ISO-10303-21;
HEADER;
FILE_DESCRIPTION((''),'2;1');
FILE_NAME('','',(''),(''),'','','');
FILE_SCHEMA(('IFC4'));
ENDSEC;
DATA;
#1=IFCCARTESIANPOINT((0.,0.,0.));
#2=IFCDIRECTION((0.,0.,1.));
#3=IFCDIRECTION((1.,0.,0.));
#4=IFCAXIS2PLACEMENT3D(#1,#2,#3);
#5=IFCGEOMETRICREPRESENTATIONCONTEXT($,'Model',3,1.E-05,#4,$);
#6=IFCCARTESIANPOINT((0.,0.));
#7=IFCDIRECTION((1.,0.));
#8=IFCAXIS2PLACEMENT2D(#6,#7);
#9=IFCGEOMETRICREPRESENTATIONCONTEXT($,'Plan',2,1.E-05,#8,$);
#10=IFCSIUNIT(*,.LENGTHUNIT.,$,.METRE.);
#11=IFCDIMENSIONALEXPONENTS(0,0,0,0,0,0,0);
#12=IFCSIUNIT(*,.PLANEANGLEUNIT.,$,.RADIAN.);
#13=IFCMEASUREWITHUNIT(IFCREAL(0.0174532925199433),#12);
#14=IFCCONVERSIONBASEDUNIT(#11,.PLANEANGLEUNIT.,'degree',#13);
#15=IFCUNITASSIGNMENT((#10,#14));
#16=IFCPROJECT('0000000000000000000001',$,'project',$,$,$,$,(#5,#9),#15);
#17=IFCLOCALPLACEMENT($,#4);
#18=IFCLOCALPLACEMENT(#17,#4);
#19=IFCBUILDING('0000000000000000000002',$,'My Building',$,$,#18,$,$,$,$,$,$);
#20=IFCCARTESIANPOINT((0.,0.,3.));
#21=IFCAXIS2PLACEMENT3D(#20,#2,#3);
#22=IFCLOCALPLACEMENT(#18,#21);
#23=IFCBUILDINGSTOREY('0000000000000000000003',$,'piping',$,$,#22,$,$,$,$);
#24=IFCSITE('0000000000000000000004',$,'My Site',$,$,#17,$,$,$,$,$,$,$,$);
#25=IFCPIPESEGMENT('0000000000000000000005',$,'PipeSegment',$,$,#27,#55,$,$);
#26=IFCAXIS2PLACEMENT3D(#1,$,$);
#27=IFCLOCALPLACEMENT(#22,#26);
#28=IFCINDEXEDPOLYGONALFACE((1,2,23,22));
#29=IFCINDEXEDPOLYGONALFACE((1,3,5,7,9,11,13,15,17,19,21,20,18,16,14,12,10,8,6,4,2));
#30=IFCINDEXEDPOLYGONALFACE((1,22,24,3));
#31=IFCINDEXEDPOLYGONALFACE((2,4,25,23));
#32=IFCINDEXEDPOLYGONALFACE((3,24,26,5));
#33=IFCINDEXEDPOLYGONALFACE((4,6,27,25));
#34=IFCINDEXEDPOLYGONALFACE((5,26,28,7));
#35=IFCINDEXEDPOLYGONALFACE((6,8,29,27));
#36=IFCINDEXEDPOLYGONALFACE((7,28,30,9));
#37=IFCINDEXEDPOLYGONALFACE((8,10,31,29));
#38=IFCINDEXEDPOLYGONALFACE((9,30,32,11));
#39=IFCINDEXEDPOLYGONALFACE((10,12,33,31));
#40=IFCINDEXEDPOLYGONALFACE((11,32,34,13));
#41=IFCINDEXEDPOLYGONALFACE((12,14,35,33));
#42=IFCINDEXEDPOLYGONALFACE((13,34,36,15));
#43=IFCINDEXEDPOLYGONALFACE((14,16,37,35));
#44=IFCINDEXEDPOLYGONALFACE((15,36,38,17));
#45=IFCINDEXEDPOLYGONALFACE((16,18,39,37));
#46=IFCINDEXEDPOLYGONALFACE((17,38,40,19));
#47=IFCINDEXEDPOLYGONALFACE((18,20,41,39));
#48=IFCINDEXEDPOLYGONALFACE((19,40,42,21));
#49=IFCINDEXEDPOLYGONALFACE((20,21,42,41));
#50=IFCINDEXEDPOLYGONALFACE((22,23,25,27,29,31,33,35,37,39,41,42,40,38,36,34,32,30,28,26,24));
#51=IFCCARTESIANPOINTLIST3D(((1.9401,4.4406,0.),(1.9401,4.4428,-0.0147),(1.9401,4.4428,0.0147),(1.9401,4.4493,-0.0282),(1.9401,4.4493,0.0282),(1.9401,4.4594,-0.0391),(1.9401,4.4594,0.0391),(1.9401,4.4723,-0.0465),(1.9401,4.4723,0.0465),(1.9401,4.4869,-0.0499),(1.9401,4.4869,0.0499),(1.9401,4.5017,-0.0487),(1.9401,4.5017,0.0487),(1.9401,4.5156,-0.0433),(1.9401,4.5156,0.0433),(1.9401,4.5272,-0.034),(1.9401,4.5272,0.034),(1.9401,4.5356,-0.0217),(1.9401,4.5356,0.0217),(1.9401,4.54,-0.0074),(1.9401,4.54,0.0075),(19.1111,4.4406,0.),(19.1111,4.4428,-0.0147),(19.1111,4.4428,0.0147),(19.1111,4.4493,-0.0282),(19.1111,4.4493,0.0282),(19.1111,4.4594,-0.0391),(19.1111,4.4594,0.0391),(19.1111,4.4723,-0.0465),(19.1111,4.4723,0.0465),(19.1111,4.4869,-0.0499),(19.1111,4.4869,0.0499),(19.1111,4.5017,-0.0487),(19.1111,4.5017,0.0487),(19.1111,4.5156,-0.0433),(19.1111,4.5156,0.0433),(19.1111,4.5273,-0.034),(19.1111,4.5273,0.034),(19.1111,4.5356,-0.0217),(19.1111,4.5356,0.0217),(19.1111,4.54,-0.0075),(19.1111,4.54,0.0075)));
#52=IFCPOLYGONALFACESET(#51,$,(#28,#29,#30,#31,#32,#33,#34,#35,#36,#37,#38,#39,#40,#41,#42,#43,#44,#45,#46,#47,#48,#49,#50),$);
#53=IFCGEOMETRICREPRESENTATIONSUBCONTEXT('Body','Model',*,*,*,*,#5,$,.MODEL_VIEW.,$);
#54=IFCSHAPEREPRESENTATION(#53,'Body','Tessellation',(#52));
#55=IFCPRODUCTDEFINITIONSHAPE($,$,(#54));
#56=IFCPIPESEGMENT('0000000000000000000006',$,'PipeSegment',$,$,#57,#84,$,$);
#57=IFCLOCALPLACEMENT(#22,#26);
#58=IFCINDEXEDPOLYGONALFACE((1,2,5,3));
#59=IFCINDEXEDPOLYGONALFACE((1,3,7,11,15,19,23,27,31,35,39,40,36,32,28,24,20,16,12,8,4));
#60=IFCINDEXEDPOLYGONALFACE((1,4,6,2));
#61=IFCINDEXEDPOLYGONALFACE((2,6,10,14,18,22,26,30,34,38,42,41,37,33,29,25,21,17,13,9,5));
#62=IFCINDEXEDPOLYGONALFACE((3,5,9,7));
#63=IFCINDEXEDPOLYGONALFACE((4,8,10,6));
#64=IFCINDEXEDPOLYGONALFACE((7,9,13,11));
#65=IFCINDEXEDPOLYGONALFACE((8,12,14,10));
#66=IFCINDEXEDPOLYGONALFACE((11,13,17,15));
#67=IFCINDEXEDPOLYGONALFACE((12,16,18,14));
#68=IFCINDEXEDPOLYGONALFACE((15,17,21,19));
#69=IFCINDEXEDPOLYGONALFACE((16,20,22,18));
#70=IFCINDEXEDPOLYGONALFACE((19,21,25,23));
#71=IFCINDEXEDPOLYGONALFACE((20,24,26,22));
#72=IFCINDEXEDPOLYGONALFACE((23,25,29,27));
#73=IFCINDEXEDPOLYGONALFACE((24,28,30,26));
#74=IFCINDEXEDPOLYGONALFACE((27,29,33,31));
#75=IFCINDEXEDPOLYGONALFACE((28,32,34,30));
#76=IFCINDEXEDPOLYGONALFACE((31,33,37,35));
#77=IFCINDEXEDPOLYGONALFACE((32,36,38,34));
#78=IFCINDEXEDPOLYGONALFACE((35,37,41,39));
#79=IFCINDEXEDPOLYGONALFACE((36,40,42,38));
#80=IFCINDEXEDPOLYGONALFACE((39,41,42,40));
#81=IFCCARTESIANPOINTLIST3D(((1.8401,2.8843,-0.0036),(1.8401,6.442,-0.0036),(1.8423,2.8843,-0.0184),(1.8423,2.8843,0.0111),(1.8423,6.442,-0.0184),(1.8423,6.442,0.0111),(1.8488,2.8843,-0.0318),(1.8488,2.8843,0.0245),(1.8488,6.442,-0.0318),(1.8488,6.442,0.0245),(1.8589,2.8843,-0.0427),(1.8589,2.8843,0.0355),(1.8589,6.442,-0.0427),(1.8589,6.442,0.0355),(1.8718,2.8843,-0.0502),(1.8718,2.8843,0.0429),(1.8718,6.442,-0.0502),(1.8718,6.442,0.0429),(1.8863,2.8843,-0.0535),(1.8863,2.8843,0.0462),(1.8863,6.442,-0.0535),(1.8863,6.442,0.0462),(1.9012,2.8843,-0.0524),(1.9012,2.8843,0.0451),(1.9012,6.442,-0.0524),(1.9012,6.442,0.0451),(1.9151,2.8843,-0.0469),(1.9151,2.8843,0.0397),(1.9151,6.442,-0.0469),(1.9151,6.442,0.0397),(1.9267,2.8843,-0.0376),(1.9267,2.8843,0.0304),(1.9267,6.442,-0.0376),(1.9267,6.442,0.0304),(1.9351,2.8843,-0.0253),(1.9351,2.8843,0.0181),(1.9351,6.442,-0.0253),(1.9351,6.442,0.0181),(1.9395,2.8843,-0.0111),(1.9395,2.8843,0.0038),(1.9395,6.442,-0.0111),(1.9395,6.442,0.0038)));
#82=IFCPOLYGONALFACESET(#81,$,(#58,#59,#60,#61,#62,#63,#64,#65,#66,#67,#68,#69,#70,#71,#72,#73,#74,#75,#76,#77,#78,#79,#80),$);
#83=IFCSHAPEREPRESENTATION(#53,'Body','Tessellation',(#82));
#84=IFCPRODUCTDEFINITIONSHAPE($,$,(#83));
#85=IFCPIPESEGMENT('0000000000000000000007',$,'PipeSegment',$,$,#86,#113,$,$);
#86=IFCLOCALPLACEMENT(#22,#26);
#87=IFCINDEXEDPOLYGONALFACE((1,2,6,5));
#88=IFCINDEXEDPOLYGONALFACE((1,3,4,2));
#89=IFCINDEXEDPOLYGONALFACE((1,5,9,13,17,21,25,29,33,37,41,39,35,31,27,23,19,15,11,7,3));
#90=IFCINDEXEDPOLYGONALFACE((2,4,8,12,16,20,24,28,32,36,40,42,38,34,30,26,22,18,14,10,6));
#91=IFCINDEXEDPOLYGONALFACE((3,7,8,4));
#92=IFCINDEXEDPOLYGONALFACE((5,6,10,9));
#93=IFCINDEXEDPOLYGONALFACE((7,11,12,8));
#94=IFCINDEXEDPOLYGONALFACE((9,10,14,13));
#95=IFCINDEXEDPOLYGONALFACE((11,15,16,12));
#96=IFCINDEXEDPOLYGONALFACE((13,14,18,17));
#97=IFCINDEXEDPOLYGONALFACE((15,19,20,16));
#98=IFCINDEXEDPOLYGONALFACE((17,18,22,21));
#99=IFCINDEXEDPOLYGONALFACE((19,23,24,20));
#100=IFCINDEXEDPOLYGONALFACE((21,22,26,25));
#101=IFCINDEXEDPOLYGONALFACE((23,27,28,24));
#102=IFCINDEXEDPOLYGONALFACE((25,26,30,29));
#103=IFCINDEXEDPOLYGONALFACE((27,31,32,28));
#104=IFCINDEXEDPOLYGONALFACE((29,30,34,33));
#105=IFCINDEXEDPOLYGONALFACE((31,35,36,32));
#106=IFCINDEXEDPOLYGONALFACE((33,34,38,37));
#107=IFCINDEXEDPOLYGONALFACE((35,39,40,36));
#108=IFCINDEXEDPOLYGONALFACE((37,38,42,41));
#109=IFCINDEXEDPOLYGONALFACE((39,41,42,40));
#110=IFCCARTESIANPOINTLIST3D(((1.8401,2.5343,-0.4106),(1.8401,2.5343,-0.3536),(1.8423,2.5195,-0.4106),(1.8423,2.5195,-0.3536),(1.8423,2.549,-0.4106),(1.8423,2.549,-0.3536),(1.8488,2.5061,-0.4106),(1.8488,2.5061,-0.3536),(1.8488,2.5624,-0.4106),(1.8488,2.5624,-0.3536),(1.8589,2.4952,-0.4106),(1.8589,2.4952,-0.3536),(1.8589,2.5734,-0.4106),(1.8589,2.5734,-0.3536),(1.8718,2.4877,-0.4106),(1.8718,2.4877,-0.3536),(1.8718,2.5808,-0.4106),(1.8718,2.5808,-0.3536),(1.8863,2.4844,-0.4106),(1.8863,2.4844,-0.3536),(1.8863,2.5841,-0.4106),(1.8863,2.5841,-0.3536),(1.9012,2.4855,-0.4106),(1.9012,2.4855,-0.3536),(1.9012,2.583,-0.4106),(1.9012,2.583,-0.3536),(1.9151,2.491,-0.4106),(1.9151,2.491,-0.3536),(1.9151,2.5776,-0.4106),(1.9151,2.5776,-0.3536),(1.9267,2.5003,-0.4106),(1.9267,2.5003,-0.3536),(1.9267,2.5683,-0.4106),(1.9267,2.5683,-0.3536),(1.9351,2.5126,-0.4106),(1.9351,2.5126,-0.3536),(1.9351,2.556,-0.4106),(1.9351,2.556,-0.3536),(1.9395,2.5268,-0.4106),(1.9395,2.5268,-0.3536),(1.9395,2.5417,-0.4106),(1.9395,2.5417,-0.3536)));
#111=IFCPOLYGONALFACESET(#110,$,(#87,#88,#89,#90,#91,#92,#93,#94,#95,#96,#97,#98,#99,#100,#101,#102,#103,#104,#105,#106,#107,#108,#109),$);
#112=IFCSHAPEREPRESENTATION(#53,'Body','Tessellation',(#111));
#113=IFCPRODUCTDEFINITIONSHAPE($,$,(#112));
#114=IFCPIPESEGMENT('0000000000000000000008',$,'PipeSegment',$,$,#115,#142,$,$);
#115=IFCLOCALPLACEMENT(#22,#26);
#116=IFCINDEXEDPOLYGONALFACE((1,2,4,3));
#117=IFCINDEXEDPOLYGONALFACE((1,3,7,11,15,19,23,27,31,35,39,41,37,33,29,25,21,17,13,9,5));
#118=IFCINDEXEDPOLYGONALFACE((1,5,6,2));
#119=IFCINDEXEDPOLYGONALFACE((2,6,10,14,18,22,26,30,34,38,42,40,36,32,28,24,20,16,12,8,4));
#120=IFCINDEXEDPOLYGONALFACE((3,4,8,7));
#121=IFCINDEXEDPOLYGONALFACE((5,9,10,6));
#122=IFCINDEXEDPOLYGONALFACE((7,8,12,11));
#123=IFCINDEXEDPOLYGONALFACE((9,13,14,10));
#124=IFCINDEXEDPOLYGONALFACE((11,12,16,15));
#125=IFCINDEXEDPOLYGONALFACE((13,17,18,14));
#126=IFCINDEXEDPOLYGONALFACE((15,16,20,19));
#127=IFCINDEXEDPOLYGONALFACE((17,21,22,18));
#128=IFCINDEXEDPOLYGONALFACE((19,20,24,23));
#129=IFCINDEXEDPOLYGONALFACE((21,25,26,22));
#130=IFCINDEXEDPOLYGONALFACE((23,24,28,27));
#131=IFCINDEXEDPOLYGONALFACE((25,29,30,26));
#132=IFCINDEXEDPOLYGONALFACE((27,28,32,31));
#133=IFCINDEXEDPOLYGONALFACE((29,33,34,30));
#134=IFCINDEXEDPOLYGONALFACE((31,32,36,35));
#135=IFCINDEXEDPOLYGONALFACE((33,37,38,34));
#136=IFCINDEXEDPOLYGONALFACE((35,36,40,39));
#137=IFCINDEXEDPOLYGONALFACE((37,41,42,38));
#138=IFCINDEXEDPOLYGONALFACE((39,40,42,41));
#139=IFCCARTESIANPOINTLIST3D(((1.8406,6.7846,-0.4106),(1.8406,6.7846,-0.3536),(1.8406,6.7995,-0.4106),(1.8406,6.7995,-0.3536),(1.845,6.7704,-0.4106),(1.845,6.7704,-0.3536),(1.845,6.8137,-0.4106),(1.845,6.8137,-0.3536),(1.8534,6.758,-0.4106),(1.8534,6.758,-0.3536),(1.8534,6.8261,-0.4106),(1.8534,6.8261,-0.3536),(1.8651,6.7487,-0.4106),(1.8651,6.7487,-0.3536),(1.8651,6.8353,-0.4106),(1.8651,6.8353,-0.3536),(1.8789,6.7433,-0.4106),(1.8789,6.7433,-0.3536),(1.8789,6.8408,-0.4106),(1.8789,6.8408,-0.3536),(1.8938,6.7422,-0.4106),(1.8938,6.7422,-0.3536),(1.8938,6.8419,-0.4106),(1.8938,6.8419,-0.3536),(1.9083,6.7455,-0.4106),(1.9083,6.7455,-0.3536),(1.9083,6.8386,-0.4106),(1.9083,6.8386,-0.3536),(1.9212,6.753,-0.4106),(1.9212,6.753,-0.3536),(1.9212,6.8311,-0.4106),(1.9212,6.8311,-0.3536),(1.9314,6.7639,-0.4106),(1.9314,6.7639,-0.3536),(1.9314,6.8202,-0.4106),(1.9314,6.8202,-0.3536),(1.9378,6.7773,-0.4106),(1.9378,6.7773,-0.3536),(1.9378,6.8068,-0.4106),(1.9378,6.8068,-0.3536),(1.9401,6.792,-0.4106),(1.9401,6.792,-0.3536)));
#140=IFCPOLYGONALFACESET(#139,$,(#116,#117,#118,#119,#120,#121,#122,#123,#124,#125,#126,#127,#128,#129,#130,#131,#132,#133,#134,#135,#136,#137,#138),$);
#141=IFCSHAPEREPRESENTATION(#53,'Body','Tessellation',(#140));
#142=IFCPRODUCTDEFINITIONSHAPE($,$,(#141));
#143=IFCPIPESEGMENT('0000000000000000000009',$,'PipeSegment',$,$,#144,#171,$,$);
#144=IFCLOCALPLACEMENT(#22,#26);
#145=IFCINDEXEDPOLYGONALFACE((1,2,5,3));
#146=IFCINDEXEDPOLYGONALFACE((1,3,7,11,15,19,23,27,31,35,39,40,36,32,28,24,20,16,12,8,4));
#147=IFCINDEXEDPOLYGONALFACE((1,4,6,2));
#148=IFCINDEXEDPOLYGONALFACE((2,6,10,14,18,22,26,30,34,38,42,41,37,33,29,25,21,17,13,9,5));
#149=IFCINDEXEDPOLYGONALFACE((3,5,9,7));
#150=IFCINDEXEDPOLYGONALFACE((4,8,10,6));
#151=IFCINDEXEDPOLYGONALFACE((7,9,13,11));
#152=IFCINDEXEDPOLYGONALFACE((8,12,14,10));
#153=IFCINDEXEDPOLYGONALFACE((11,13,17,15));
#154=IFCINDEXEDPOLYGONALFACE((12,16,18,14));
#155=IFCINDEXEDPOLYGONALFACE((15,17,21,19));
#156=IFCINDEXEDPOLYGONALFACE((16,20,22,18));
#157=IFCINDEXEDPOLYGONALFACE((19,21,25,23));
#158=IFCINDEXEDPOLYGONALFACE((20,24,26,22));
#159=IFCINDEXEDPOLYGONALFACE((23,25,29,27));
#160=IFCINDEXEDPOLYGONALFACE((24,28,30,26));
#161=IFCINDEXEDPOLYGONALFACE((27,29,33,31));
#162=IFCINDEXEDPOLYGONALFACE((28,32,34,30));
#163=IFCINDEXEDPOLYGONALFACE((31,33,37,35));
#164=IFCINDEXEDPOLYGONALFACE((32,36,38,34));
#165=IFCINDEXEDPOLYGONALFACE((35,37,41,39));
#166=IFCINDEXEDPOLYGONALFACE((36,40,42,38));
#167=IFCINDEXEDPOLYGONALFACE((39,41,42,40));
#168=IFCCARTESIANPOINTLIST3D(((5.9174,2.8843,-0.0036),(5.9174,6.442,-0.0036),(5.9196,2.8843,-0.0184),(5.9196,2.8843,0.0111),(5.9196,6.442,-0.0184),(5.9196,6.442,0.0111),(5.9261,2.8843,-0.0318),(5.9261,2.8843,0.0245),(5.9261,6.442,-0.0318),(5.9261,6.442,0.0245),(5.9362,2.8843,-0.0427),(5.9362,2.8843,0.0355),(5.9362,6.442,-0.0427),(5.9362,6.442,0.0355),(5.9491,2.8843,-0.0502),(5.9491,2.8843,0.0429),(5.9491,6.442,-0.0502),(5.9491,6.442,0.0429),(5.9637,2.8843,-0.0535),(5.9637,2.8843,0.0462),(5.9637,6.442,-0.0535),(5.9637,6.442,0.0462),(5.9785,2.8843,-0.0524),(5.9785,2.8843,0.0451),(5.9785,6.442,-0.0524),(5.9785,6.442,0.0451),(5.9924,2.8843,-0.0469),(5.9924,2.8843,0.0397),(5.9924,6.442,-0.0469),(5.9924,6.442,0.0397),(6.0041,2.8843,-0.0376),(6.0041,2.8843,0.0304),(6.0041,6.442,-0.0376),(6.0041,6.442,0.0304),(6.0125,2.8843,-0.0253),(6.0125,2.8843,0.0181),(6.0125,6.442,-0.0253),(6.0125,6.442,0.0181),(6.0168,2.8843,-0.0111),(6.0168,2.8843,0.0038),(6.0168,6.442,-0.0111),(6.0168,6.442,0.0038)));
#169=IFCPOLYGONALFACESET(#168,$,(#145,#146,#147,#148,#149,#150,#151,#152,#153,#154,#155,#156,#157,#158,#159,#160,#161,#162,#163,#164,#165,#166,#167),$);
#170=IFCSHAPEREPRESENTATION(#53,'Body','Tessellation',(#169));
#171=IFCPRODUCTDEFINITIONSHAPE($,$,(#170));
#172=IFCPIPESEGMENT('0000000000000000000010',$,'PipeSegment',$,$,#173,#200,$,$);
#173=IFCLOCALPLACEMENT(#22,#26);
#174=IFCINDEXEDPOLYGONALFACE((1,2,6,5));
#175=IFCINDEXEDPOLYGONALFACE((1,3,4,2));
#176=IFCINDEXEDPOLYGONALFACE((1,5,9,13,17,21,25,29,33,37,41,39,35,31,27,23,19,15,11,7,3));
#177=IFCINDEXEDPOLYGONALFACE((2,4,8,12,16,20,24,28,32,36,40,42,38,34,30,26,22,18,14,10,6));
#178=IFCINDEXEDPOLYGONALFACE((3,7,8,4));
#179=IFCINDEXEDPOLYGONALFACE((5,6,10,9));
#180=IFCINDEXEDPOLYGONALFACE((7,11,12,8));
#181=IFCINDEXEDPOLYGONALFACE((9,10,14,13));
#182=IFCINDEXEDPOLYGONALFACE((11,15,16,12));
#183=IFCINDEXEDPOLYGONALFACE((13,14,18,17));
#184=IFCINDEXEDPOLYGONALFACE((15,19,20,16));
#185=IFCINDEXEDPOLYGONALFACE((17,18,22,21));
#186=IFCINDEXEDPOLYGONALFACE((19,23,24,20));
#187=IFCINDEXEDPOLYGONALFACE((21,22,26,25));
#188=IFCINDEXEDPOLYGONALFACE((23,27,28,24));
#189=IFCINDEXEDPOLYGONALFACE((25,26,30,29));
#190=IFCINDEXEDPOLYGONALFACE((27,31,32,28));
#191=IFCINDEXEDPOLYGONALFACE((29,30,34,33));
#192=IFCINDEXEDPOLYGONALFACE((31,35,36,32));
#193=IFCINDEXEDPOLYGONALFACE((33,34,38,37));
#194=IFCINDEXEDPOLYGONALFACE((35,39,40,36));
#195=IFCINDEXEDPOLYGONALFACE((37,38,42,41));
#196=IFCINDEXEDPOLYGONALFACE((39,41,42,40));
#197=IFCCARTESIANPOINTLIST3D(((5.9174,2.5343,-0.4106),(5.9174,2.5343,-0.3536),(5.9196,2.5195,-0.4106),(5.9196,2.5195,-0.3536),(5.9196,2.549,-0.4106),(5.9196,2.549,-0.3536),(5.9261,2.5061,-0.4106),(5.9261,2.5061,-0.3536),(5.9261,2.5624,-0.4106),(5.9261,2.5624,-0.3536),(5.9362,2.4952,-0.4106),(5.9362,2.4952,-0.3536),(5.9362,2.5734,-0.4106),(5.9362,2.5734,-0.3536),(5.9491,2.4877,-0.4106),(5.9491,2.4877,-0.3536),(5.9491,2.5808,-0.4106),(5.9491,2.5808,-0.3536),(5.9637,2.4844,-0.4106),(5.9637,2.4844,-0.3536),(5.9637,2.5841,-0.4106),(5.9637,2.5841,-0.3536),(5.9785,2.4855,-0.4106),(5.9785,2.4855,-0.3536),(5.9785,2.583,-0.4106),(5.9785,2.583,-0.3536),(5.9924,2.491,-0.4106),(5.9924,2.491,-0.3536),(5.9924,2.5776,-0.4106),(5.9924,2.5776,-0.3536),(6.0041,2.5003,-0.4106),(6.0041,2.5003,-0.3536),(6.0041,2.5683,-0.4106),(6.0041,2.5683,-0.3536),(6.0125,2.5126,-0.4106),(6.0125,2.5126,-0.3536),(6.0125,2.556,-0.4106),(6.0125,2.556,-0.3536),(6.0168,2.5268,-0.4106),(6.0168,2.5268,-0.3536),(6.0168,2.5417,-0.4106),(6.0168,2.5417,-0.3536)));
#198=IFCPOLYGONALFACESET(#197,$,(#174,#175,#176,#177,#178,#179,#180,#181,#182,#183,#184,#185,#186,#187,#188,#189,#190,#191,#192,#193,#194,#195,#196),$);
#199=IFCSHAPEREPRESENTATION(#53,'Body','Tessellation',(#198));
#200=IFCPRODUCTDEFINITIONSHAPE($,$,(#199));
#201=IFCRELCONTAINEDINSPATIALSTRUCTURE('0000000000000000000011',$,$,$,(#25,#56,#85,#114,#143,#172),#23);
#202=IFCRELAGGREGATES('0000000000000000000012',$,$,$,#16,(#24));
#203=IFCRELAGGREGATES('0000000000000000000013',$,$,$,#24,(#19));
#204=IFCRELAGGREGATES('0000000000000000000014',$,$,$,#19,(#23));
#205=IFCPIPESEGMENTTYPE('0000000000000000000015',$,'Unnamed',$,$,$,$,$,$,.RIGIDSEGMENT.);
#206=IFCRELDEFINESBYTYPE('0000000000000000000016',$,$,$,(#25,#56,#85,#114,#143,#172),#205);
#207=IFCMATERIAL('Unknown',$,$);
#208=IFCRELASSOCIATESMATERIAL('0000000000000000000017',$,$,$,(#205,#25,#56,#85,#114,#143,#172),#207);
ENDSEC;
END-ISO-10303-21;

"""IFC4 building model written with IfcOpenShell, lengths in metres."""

from ifc_helpers import new_model, entity, si_unit, converted_unit, frame, origin_with_axes, origin_2d_with_axis, place, context, subcontext, project, spatial, circle, extrude, material, material_profile, profile_set, profile_usage, type_object, element, save


model = new_model("IFC4")

# Units and contexts
model_context = context("Model", 3, precision=1e-05, world=origin_with_axes())
plan_context = context("Plan", 2, precision=1e-05, world=origin_2d_with_axis())
body_context = subcontext(model_context, "Body", "Model", "MODEL_VIEW")
ifc_project = project(units=[si_unit("LENGTHUNIT", "METRE"), converted_unit("PLANEANGLEUNIT", "degree", entity("IfcReal", 0.0174532925199433), si_unit("PLANEANGLEUNIT", "RADIAN"), dimensions=[0, 0, 0, 0, 0, 0, 0])], contexts=[model_context, plan_context])

# Site, building, storey
site_placement = place(None, origin_with_axes())
site = spatial("IfcSite", under=ifc_project, at=site_placement, Name="My Site")
building_placement = place(site_placement, origin_with_axes())
building = spatial("IfcBuilding", under=site, at=building_placement, Name="My Building")
storey_placement = place(building_placement, frame((0.0, 0.0, 3.0), z_axis=(0.0, 0.0, 1.0), x_axis=(1.0, 0.0, 0.0)))
storey = spatial("IfcBuildingStorey", under=building, at=storey_placement, Name="piping")

# Pipe segments
ifc_material = material(Name="Unknown")
ifc_material_profile = material_profile(ifc_material, circle(Radius=0.05))
ifc_profile_set = profile_set([ifc_material_profile])
ifc_profile_usage_1 = profile_usage(ifc_profile_set, cardinal=5)
pipe_segment_type = type_object("IfcPipeSegmentType", Name="Unnamed", PredefinedType="RIGIDSEGMENT", material=ifc_profile_set)
pipe_segment_1_placement = place(storey_placement, frame((19.1111, 4.4906, 0.0), z_axis=(-1.0, 0.0, 0.0), x_axis=(0.0, -1.0, 0.0)))
element("IfcPipeSegment", 1, at=pipe_segment_1_placement, inside=storey, type_object=pipe_segment_type, material=ifc_profile_usage_1, Name="PipeSegment", context=body_context, shape_type="SweptSolid", body=[
    extrude(circle(Radius=0.05), origin_with_axes(), (0.0, 0.0, 1.0), 17.1711),
])
ifc_profile_usage_2 = profile_usage(ifc_profile_set, cardinal=5)
pipe_segment_2_placement = place(storey_placement, frame((1.8901, 2.8843, -0.0036), z_axis=(0.0, 1.0, 0.0), x_axis=(-1.0, 0.0, 0.0)))
element("IfcPipeSegment", 2, at=pipe_segment_2_placement, inside=storey, type_object=pipe_segment_type, material=ifc_profile_usage_2, Name="PipeSegment", context=body_context, shape_type="SweptSolid", body=[
    extrude(circle(Radius=0.05), origin_with_axes(), (0.0, 0.0, 1.0), 3.5578),
])
ifc_profile_usage_3 = profile_usage(ifc_profile_set, cardinal=5)
pipe_segment_3_placement = place(storey_placement, frame((1.8901, 2.5343, -0.3536), z_axis=(0.0, 0.0, -1.0), x_axis=(-1.0, 0.0, 0.0)))
element("IfcPipeSegment", 3, at=pipe_segment_3_placement, inside=storey, type_object=pipe_segment_type, material=ifc_profile_usage_3, Name="PipeSegment", context=body_context, shape_type="SweptSolid", body=[
    extrude(circle(Radius=0.05), origin_with_axes(), (0.0, 0.0, 1.0), 0.057),
])
ifc_profile_usage_4 = profile_usage(ifc_profile_set, cardinal=5)
pipe_segment_4_placement = place(storey_placement, frame((1.8901, 6.792, -0.3536), z_axis=(0.0, 0.0, -1.0), x_axis=(1.0, 0.0, 0.0)))
element("IfcPipeSegment", 4, at=pipe_segment_4_placement, inside=storey, type_object=pipe_segment_type, material=ifc_profile_usage_4, Name="PipeSegment", context=body_context, shape_type="SweptSolid", body=[
    extrude(circle(Radius=0.05), origin_with_axes(), (0.0, 0.0, 1.0), 0.057),
])
ifc_profile_usage_5 = profile_usage(ifc_profile_set, cardinal=5)
pipe_segment_5_placement = place(storey_placement, frame((5.9674, 2.8843, -0.0036), z_axis=(0.0, 1.0, 0.0), x_axis=(-1.0, 0.0, 0.0)))
element("IfcPipeSegment", 5, at=pipe_segment_5_placement, inside=storey, type_object=pipe_segment_type, material=ifc_profile_usage_5, Name="PipeSegment", context=body_context, shape_type="SweptSolid", body=[
    extrude(circle(Radius=0.05), origin_with_axes(), (0.0, 0.0, 1.0), 3.5578),
])
ifc_profile_usage_6 = profile_usage(ifc_profile_set, cardinal=5)
pipe_segment_6_placement = place(storey_placement, frame((5.9674, 2.5343, -0.3536), z_axis=(0.0, 0.0, -1.0), x_axis=(-1.0, 0.0, 0.0)))
element("IfcPipeSegment", 6, at=pipe_segment_6_placement, inside=storey, type_object=pipe_segment_type, material=ifc_profile_usage_6, Name="PipeSegment", context=body_context, shape_type="SweptSolid", body=[
    extrude(circle(Radius=0.05), origin_with_axes(), (0.0, 0.0, 1.0), 0.057),
])

save(model, "model.ifc")
